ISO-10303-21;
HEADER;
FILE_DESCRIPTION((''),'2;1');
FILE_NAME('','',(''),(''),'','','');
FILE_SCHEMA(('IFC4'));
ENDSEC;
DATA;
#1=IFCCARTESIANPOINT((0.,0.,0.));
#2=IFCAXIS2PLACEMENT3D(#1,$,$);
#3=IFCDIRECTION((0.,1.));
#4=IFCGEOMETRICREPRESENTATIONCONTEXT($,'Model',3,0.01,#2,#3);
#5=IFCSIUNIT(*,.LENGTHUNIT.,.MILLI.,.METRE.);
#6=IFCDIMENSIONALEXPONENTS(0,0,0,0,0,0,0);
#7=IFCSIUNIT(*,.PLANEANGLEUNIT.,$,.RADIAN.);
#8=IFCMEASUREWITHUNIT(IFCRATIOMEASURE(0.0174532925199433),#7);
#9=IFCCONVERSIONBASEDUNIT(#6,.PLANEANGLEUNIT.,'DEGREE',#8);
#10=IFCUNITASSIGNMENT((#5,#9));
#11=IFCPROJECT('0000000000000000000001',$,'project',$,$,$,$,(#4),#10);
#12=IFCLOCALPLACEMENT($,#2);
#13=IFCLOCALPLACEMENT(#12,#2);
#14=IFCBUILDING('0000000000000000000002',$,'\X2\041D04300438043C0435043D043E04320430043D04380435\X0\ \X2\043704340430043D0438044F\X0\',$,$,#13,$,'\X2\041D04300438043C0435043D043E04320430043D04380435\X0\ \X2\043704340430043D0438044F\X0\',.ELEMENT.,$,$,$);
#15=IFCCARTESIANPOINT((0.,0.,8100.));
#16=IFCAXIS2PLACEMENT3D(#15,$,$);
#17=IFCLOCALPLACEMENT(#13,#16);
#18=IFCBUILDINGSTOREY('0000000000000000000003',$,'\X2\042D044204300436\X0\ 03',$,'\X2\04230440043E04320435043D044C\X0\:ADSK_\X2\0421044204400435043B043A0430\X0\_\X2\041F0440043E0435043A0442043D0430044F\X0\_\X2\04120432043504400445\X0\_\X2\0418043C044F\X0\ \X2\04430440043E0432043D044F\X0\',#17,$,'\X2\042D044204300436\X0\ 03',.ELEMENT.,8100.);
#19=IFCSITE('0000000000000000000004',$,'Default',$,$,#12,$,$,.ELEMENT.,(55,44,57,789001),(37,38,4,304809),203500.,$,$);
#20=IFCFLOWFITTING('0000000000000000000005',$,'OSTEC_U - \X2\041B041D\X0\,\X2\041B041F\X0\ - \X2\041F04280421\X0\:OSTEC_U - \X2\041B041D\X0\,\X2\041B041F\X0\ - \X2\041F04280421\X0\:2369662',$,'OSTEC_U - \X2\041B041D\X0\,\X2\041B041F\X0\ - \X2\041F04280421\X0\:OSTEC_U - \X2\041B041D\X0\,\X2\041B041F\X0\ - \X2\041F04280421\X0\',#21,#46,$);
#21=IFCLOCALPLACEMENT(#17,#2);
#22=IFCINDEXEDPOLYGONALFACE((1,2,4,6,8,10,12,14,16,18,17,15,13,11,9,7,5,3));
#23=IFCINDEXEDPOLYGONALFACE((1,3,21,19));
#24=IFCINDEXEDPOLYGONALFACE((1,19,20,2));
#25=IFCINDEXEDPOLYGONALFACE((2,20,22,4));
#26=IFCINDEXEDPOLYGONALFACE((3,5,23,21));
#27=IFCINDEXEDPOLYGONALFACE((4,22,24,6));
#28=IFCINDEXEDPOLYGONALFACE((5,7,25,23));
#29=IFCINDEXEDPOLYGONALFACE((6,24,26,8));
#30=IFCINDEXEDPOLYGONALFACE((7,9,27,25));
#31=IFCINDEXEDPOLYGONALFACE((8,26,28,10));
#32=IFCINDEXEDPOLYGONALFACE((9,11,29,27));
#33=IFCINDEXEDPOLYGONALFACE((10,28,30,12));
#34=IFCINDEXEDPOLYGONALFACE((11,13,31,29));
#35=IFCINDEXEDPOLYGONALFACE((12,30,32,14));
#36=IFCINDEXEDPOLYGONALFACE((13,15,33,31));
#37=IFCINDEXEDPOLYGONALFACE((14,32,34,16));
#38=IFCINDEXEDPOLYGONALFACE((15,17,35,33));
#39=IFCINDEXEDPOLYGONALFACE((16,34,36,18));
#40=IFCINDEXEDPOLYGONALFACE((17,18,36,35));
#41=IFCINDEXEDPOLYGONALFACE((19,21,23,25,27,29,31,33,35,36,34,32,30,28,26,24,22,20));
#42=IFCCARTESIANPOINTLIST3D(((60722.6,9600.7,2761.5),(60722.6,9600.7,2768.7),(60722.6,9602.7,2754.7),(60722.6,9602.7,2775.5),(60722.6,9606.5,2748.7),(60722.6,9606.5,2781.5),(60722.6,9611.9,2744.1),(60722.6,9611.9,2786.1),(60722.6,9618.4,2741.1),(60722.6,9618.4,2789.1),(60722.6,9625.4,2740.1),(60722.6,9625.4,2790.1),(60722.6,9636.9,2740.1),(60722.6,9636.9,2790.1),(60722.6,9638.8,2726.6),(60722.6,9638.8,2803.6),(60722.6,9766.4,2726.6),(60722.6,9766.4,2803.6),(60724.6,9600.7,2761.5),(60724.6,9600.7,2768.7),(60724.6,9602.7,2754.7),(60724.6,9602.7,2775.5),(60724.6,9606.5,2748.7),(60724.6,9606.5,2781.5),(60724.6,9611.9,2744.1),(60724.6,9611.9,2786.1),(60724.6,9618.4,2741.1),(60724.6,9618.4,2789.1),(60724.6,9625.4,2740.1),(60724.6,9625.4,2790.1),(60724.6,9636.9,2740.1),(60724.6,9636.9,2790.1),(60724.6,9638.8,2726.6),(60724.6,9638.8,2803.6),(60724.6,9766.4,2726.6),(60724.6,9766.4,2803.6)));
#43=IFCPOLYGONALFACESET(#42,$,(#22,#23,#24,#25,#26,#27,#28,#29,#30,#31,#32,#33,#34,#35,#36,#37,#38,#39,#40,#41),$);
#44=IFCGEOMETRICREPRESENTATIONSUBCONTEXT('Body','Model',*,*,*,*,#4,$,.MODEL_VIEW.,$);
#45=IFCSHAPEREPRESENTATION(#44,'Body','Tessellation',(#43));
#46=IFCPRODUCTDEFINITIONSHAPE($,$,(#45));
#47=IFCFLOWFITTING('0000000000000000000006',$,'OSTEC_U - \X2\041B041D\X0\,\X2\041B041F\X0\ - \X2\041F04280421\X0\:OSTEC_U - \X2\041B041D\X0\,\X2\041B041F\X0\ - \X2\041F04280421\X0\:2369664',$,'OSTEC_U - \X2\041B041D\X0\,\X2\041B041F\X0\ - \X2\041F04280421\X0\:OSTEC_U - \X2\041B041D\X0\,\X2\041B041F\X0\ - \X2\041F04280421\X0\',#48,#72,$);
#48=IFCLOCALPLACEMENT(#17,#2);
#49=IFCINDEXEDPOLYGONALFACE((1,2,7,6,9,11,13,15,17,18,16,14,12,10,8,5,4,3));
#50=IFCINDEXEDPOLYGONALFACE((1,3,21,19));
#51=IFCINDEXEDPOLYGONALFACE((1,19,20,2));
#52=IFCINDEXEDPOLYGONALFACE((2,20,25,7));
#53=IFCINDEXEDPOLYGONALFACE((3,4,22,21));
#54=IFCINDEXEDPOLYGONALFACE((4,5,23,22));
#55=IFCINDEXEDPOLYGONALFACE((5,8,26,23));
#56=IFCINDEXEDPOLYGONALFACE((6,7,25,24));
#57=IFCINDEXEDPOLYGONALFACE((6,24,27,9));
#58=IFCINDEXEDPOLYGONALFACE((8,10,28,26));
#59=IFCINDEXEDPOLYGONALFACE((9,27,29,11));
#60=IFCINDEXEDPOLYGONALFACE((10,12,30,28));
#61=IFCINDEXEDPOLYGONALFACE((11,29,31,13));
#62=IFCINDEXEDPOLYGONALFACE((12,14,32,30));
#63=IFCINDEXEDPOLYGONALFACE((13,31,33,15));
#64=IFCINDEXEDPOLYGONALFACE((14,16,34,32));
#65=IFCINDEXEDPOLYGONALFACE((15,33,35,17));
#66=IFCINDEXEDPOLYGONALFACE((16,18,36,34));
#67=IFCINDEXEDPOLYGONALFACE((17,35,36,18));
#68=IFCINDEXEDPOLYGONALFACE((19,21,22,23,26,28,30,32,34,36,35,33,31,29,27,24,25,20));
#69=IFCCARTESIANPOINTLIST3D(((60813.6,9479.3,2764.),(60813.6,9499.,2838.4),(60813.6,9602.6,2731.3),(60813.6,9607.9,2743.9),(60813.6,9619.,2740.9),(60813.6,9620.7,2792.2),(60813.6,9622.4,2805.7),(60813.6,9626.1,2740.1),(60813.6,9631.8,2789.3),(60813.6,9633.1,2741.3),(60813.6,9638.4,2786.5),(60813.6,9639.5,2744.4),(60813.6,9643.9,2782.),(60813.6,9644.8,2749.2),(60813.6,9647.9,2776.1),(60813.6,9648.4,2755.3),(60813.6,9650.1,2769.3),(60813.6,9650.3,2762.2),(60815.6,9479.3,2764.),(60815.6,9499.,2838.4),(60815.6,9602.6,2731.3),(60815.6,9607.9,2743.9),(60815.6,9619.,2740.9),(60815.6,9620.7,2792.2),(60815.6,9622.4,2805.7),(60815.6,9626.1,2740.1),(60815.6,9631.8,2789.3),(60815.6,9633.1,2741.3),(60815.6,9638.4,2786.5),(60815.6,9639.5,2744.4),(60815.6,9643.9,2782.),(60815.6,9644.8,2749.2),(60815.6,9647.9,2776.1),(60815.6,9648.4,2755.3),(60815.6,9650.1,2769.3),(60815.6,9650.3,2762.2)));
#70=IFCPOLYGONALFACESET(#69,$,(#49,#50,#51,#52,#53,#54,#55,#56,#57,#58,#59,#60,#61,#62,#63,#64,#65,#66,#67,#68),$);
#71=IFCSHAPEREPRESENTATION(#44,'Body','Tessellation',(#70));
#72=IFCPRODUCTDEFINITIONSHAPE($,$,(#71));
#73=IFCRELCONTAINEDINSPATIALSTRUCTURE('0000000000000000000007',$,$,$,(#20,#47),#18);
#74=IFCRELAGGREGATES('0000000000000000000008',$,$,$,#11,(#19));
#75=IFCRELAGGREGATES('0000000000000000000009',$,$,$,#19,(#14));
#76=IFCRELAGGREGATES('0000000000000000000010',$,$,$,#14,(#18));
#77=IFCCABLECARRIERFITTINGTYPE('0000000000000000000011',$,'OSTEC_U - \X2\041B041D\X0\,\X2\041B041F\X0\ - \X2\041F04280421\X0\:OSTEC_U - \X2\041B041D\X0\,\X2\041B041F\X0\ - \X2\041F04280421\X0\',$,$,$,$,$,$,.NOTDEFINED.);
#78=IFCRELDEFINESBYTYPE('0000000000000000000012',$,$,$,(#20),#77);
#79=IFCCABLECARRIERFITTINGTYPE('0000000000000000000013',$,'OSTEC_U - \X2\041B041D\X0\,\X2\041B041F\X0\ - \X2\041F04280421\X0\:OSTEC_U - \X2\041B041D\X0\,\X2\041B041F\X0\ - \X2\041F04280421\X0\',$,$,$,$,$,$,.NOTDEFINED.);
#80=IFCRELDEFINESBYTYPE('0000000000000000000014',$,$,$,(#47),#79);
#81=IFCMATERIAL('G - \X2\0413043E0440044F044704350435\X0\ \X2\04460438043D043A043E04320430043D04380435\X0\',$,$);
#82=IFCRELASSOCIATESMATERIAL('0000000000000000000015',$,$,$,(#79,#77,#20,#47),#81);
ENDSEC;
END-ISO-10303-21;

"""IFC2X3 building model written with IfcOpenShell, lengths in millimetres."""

from ifc_helpers import new_model, entity, si_unit, converted_unit, direction, frame, frame_2d, origin, place, context, subcontext, project, spatial, polyline, circle_curve, parameter, trimmed, segment, composite_curve, outline, extrude, source, transform, mapped, material, type_object, type_shapes, element, save


model = new_model("IFC2X3")

# Units and contexts
model_context = context("Model", 3, precision=0.01, world=origin(), true_north=direction((0.0, 1.0)))
body_context = subcontext(model_context, "Body", "Model", "MODEL_VIEW")
ifc_project = project(units=[si_unit("LENGTHUNIT", "METRE", prefix="MILLI"), converted_unit("PLANEANGLEUNIT", "DEGREE", entity("IfcRatioMeasure", 0.0174532925199433), si_unit("PLANEANGLEUNIT", "RADIAN"), dimensions=[0, 0, 0, 0, 0, 0, 0])], contexts=[model_context])

# Site, building, storey
site_placement = place(None, origin())
site = spatial("IfcSite", under=ifc_project, at=site_placement, Name="Default", CompositionType="ELEMENT", RefLatitude=(55, 44, 57, 789001), RefLongitude=(37, 38, 4, 304809), RefElevation=203500.0)
building_placement = place(site_placement, origin())
building = spatial("IfcBuilding", under=site, at=building_placement, Name="Наименование здания", LongName="Наименование здания", CompositionType="ELEMENT")
storey_placement = place(building_placement, frame((0.0, 0.0, 8100.0)))
storey = spatial("IfcBuildingStorey", under=building, at=storey_placement, Name="Этаж 03", ObjectType="Уровень:ADSK_Стрелка_Проектная_Вверх_Имя уровня", LongName="Этаж 03", CompositionType="ELEMENT", Elevation=8100.0)

# Flow fittings
ifc_material_1 = material(Name="G - Горячее цинкование")
cable_carrier_fitting_type_1 = type_object("IfcCableCarrierFittingType", Name="OSTEC_U - ЛН,ЛП - ПШС:OSTEC_U - ЛН,ЛП - ПШС", PredefinedType="NOTDEFINED", material=ifc_material_1)
shared_shape_1 = source(origin(), body_context, "Body", "SweptSolid", [
    extrude(outline(composite_curve([segment(trimmed(circle_curve(frame_2d((-41.5, 0.0), x_axis=(1.0, 0.0)), 25.0), [parameter(90.0)], [parameter(270.0)], True, "PARAMETER"), True, "CONTINUOUS"), segment(polyline([(-41.5, -25.0), (-30.0, -25.0)]), True, "CONTINUOUS"), segment(polyline([(-30.0, -25.0), (-28.1, -38.5)]), True, "CONTINUOUS"), segment(polyline([(-28.1, -38.5), (99.5, -38.5)]), True, "CONTINUOUS"), segment(polyline([(99.5, -38.5), (99.5, 38.5)]), True, "CONTINUOUS"), segment(polyline([(99.5, 38.5), (-28.1, 38.5)]), True, "CONTINUOUS"), segment(polyline([(-28.1, 38.5), (-30.0, 25.0)]), True, "CONTINUOUS"), segment(polyline([(-30.0, 25.0), (-41.5, 25.0)]), True, "CONTINUOUS")], self_intersect=False)), frame((41.5, 0.0, 0.0)), (0.0, 0.0, 1.0), 2.0),
])
type_shapes(cable_carrier_fitting_type_1, [shared_shape_1])
cable_carrier_fitting_type_2 = type_object("IfcCableCarrierFittingType", Name="OSTEC_U - ЛН,ЛП - ПШС:OSTEC_U - ЛН,ЛП - ПШС", PredefinedType="NOTDEFINED", material=ifc_material_1)
type_shapes(cable_carrier_fitting_type_2, [shared_shape_1])
flow_fitting_1_placement = place(storey_placement, frame((60724.7, 9625.4, 2765.1), z_axis=(-1.0, 0.0, 0.0), x_axis=(0.0, 1.0, -0.000005)))
element("IfcFlowFitting", 1, at=flow_fitting_1_placement, inside=storey, type_object=cable_carrier_fitting_type_2, material=ifc_material_1, Name="OSTEC_U - ЛН,ЛП - ПШС:OSTEC_U - ЛН,ЛП - ПШС:2369662", ObjectType="OSTEC_U - ЛН,ЛП - ПШС:OSTEC_U - ЛН,ЛП - ПШС", context=body_context, shape_type="MappedRepresentation", body=[
    mapped(shared_shape_1, transform((0.0, 0.0, 0.0), scale=1.0)),
])
flow_fitting_2_placement = place(storey_placement, frame((60813.6, 9625.4, 2765.1), z_axis=(1.0, 0.0, 0.0), x_axis=(0.0, -0.966668, 0.256034)))
element("IfcFlowFitting", 2, at=flow_fitting_2_placement, inside=storey, type_object=cable_carrier_fitting_type_1, material=ifc_material_1, Name="OSTEC_U - ЛН,ЛП - ПШС:OSTEC_U - ЛН,ЛП - ПШС:2369664", ObjectType="OSTEC_U - ЛН,ЛП - ПШС:OSTEC_U - ЛН,ЛП - ПШС", context=body_context, shape_type="MappedRepresentation", body=[
    mapped(shared_shape_1, transform((0.0, 0.0, 0.0), scale=1.0)),
])

save(model, "model.ifc")
